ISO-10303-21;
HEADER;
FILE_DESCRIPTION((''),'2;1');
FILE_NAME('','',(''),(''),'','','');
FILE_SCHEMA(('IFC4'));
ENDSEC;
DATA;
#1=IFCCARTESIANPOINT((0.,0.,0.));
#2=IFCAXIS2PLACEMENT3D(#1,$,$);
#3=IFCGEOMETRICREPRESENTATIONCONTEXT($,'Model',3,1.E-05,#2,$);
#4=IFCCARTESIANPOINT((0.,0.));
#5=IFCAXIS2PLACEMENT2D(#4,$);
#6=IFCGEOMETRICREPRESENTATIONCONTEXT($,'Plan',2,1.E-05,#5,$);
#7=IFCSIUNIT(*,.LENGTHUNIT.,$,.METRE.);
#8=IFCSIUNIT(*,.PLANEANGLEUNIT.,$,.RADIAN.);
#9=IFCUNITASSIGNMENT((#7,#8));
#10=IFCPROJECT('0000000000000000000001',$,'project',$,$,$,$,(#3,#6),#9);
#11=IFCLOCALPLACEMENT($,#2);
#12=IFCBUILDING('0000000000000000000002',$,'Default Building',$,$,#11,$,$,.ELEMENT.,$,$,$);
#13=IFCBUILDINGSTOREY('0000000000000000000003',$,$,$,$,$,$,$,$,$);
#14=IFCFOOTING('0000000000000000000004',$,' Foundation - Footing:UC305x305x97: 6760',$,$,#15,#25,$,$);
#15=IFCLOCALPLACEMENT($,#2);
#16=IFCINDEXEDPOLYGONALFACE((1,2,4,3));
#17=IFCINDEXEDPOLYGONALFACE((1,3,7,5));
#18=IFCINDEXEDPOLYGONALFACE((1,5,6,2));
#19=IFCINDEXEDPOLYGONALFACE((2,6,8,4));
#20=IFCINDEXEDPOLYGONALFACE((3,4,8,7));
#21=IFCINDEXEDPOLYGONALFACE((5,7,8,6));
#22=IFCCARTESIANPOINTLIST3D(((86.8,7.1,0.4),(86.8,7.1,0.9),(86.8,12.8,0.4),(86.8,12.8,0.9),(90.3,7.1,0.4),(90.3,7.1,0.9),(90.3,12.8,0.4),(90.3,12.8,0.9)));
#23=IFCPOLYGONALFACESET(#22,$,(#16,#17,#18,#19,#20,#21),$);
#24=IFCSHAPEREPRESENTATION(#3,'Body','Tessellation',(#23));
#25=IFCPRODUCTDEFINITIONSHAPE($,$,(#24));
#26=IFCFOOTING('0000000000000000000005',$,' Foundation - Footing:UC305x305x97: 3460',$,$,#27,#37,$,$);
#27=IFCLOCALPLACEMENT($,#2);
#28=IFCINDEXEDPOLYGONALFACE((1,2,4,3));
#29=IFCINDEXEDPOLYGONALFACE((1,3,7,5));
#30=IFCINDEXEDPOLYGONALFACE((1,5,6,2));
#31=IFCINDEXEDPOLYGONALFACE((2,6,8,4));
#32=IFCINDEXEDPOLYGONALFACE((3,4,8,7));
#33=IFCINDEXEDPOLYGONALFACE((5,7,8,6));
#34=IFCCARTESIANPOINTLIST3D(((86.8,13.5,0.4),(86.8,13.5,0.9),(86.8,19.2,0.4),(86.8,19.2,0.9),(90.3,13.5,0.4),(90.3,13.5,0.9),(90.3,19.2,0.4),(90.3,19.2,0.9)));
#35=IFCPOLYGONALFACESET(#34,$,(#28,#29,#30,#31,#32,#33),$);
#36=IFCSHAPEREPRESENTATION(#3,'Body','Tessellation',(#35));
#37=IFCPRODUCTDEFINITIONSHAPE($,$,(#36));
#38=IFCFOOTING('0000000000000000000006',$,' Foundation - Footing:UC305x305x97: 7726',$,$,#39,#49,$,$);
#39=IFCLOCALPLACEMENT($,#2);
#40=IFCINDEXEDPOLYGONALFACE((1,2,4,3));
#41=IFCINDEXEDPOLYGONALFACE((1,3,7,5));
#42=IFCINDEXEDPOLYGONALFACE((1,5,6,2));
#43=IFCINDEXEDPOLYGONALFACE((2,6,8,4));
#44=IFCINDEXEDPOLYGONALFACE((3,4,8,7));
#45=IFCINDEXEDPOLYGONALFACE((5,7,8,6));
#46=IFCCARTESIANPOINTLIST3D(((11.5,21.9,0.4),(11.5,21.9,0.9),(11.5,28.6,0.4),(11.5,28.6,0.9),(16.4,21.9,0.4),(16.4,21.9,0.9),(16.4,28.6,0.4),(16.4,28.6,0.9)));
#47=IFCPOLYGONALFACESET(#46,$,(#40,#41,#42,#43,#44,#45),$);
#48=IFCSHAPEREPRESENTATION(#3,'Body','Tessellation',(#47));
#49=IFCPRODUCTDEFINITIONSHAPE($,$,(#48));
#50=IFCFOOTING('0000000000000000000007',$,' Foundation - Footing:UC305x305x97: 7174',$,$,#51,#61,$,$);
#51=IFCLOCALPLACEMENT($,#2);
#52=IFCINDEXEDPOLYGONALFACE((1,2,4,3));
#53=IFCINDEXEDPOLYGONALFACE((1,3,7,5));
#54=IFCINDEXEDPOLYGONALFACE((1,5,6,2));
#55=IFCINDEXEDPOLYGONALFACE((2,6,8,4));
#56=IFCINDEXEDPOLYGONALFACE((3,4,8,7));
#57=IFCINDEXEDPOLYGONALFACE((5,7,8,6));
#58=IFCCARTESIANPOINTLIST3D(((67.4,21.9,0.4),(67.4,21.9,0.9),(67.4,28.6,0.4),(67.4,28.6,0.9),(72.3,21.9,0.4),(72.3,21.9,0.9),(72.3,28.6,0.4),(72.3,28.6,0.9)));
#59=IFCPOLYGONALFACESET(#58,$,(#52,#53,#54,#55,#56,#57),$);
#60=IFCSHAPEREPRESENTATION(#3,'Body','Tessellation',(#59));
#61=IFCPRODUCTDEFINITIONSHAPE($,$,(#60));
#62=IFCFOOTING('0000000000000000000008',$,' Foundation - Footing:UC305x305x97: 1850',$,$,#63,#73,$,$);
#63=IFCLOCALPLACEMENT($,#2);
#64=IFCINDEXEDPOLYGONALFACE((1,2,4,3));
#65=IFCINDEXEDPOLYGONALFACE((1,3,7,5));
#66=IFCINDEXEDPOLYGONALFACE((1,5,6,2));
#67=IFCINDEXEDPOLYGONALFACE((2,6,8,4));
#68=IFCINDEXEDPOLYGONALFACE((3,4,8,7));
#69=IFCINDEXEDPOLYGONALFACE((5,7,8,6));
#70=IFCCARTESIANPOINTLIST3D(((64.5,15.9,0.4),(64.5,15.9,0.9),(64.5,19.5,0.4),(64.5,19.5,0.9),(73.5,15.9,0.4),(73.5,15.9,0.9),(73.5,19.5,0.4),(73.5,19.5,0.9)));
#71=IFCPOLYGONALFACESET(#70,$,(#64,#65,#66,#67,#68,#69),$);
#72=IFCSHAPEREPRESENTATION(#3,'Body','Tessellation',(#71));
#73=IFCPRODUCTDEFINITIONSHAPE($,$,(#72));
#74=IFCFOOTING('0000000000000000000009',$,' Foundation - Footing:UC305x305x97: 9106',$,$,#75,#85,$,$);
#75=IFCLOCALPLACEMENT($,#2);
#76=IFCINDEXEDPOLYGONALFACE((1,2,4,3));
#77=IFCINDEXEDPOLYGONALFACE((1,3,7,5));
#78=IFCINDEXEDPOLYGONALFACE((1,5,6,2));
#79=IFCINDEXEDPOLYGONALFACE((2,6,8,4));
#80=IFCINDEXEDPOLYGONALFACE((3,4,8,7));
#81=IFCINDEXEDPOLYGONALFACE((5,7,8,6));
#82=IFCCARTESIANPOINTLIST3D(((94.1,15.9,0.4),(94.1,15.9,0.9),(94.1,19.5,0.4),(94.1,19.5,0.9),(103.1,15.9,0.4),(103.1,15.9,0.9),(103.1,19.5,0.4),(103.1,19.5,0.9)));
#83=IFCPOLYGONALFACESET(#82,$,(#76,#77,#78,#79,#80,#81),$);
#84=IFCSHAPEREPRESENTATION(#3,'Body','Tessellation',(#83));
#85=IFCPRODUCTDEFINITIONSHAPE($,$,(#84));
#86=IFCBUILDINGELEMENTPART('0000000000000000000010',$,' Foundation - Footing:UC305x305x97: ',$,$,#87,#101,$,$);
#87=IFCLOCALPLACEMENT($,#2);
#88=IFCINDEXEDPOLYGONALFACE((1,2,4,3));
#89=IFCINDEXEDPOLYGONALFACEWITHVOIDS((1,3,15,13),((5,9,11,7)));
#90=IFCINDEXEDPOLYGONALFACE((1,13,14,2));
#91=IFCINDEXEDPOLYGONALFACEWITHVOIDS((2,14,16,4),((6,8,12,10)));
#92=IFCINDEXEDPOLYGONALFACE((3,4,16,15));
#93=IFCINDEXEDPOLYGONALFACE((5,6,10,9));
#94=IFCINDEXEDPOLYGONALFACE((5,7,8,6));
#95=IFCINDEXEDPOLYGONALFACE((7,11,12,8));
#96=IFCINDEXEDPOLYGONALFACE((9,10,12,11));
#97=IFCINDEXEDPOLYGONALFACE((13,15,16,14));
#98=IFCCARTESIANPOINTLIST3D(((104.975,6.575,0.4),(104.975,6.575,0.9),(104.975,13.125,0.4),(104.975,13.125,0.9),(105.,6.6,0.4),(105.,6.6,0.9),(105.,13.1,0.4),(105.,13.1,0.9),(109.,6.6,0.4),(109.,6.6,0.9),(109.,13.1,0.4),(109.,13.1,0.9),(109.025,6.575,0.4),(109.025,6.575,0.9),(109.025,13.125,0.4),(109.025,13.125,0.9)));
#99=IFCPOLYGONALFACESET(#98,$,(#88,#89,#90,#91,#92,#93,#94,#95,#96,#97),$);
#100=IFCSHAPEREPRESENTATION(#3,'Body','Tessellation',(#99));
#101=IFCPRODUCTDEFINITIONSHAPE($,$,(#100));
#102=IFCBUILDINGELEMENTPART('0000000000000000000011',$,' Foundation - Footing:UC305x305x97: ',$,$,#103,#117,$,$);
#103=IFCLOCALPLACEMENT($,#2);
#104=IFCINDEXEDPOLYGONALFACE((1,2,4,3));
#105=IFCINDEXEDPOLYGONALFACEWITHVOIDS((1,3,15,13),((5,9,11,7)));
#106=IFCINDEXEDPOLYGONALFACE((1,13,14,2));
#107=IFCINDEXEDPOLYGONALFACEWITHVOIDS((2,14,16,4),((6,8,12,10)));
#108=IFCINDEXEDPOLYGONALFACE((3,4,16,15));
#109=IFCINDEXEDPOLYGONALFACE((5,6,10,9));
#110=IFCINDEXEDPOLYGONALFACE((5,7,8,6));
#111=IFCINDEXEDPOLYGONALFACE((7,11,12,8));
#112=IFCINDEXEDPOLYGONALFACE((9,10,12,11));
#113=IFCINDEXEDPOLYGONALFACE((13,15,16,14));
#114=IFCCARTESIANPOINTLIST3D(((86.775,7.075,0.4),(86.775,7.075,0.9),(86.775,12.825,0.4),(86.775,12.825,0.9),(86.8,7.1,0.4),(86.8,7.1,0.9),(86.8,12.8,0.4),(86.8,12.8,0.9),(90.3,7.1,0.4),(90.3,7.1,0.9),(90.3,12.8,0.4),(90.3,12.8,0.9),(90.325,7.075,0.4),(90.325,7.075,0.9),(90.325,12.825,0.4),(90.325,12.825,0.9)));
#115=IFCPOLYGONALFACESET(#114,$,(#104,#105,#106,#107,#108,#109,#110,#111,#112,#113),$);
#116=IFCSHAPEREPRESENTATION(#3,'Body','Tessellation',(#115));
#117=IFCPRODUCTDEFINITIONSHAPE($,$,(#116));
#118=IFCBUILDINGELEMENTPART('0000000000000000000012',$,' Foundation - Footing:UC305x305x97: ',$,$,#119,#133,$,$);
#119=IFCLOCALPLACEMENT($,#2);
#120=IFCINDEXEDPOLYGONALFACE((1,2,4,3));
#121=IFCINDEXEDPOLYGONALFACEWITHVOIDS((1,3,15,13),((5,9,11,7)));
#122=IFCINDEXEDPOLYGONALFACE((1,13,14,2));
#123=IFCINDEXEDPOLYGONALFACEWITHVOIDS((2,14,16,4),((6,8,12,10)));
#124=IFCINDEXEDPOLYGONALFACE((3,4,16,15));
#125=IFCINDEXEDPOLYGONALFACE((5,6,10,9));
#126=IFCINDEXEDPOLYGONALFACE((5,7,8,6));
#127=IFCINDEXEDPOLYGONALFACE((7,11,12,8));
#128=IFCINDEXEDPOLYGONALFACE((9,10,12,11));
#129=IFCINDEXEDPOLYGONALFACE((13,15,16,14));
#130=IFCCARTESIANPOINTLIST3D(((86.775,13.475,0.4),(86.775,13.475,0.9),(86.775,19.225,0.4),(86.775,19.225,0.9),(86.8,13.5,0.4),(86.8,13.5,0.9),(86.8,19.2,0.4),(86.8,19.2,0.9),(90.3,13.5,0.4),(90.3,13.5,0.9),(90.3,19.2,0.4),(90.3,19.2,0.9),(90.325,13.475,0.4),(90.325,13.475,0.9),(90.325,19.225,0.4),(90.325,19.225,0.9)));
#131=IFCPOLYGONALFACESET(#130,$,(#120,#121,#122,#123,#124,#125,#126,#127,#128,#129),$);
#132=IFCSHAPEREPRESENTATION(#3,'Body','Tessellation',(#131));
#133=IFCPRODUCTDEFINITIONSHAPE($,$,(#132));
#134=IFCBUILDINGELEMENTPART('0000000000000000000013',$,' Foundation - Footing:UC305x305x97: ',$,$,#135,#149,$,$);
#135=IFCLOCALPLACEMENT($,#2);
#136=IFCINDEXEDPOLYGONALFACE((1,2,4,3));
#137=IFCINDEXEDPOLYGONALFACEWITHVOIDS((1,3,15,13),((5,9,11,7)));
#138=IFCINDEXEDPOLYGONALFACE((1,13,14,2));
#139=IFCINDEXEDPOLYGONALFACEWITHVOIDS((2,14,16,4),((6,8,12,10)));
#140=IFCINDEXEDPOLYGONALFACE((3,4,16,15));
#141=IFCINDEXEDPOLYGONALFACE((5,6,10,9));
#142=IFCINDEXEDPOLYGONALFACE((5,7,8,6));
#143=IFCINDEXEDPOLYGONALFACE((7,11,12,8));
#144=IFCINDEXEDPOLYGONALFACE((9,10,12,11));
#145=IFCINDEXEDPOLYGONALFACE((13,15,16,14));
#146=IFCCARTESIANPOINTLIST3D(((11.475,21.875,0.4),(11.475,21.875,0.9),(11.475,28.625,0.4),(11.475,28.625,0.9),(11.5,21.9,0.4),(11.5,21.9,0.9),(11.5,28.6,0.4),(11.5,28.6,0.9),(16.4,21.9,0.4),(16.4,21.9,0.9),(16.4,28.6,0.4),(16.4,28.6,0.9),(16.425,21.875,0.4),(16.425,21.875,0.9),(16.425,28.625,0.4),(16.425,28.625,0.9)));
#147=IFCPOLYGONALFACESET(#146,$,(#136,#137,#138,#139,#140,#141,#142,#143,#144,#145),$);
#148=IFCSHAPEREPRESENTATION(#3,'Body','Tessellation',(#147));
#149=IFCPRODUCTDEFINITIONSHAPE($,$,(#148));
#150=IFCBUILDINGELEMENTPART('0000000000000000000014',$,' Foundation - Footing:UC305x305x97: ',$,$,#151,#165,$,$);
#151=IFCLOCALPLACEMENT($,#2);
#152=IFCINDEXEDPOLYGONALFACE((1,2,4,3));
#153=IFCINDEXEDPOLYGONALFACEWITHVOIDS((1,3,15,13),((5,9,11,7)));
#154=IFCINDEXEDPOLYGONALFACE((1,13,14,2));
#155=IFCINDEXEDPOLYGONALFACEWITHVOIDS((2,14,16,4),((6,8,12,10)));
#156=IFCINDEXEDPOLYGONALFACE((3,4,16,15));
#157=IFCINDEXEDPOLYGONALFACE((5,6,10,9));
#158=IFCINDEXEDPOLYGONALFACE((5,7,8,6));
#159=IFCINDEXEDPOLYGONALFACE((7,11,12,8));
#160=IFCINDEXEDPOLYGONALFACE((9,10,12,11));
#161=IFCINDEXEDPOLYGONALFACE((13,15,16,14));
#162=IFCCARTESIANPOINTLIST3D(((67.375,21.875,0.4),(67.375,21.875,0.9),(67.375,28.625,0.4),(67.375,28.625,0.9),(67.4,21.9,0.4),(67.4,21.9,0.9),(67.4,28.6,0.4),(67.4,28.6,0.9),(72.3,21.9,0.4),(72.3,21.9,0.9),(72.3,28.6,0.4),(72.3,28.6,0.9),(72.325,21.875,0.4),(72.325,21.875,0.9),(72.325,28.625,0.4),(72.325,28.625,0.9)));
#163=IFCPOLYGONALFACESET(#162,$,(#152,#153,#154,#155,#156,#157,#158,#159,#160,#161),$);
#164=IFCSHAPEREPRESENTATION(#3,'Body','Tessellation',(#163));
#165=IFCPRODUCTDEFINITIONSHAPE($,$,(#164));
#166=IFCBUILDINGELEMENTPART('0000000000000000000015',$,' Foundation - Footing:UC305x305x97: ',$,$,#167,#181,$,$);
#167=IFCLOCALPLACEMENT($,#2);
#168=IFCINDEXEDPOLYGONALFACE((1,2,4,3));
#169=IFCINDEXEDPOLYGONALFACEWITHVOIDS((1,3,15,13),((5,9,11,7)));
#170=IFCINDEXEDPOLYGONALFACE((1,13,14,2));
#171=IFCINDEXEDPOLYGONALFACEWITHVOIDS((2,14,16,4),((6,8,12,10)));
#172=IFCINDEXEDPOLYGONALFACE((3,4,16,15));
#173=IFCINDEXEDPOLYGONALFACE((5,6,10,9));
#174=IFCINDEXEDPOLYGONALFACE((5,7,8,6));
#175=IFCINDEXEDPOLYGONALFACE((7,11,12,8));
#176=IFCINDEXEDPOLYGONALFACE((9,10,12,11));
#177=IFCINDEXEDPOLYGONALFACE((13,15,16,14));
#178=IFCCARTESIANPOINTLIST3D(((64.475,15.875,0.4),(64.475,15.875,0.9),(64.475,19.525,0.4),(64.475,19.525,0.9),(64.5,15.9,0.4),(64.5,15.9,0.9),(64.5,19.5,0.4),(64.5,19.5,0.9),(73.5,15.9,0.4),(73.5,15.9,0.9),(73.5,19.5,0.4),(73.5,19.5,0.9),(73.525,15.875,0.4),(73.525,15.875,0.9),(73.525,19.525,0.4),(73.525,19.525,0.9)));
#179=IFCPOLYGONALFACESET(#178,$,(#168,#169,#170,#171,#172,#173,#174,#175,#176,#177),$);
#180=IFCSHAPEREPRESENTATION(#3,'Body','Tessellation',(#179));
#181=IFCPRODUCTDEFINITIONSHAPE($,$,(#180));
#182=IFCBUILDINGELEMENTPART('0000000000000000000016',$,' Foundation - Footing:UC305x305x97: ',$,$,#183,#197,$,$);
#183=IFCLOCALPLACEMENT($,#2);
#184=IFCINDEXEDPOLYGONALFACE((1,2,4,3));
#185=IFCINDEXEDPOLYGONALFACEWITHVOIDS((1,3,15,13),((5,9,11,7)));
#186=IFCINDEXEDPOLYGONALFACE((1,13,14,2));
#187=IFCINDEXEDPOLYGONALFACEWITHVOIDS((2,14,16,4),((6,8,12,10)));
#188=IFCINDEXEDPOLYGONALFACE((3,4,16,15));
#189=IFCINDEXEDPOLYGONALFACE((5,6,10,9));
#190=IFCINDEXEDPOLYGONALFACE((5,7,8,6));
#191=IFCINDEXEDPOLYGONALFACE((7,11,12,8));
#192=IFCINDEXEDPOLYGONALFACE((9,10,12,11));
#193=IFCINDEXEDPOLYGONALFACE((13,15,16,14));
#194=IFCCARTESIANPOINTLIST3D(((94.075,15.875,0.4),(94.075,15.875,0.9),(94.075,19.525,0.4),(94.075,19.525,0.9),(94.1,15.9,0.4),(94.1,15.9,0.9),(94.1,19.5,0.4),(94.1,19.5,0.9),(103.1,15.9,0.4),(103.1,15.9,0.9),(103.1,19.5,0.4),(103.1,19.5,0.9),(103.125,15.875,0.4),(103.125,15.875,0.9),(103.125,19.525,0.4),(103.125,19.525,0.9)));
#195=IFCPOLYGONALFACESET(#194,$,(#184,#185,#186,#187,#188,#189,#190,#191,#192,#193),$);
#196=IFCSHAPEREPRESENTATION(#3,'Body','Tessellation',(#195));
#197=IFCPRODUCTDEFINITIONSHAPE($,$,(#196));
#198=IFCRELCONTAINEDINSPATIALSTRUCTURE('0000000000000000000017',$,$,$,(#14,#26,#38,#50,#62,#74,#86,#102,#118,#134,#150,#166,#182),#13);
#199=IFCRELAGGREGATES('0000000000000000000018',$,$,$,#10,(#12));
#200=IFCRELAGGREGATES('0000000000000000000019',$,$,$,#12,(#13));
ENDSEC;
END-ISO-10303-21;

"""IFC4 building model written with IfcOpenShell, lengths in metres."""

from ifc_helpers import new_model, si_unit, origin, origin_2d, place, context, project, spatial, polyline, outline, extrude, element, save


model = new_model("IFC4")

# Units and contexts
model_context = context("Model", 3, precision=1e-05, world=origin())
plan_context = context("Plan", 2, precision=1e-05, world=origin_2d())
ifc_project = project(units=[si_unit("LENGTHUNIT", "METRE"), si_unit("PLANEANGLEUNIT", "RADIAN")], contexts=[model_context, plan_context])

# Building, storey
building_placement = place(None, origin())
building = spatial("IfcBuilding", under=ifc_project, at=building_placement, Name="Default Building", CompositionType="ELEMENT")
storey = spatial("IfcBuildingStorey", under=building)

# Footings
element("IfcFooting", 1, inside=storey, Name=" Foundation - Footing:UC305x305x97: 6760", context=model_context, shape_type="SweptSolid", body=[
    extrude(outline(polyline([(86.8, 12.8, 0.4), (90.3, 12.8, 0.4), (90.3, 7.1, 0.4), (86.8, 7.1, 0.4), (86.8, 12.8, 0.4)])), None, (0.0, 0.0, 1.0), 0.5),
])
element("IfcFooting", 2, inside=storey, Name=" Foundation - Footing:UC305x305x97: 3460", context=model_context, shape_type="SweptSolid", body=[
    extrude(outline(polyline([(86.8, 19.2, 0.4), (90.3, 19.2, 0.4), (90.3, 13.5, 0.4), (86.8, 13.5, 0.4), (86.8, 19.2, 0.4)])), None, (0.0, 0.0, 1.0), 0.5),
])
element("IfcFooting", 3, inside=storey, Name=" Foundation - Footing:UC305x305x97: 7726", context=model_context, shape_type="SweptSolid", body=[
    extrude(outline(polyline([(16.4, 21.9, 0.4), (16.4, 28.6, 0.4), (11.5, 28.6, 0.4), (11.5, 21.9, 0.4), (16.4, 21.9, 0.4)])), None, (0.0, 0.0, 1.0), 0.5),
])
element("IfcFooting", 4, inside=storey, Name=" Foundation - Footing:UC305x305x97: 7174", context=model_context, shape_type="SweptSolid", body=[
    extrude(outline(polyline([(67.4, 21.9, 0.4), (67.4, 28.6, 0.4), (72.3, 28.6, 0.4), (72.3, 21.9, 0.4), (67.4, 21.9, 0.4)])), None, (0.0, 0.0, 1.0), 0.5),
])
element("IfcFooting", 5, inside=storey, Name=" Foundation - Footing:UC305x305x97: 1850", context=model_context, shape_type="SweptSolid", body=[
    extrude(outline(polyline([(64.5, 19.5, 0.4), (73.5, 19.5, 0.4), (73.5, 15.9, 0.4), (64.5, 15.9, 0.4), (64.5, 19.5, 0.4)])), None, (0.0, 0.0, 1.0), 0.5),
])
element("IfcFooting", 6, inside=storey, Name=" Foundation - Footing:UC305x305x97: 9106", context=model_context, shape_type="SweptSolid", body=[
    extrude(outline(polyline([(94.1, 19.5, 0.4), (103.1, 19.5, 0.4), (103.1, 15.9, 0.4), (94.1, 15.9, 0.4), (94.1, 19.5, 0.4)])), None, (0.0, 0.0, 1.0), 0.5),
])

# Building element parts, openings
building_element_part_1 = element("IfcBuildingElementPart", 7, inside=storey, Name=" Foundation - Footing:UC305x305x97: ", context=model_context, shape_type="SweptSolid", body=[
    extrude(outline(polyline([(109.025, 13.125, 0.4), (104.975, 13.125, 0.4), (104.975, 6.575, 0.4), (109.025, 6.575, 0.4), (109.025, 13.125, 0.4)])), None, (0.0, 0.0, 1.0), 0.5),
])
element("IfcOpeningElement", 8, inside=storey, cuts=building_element_part_1, context=model_context, shape_type="SweptSolid", body=[
    extrude(outline(polyline([(109.0, 13.1, 0.4), (105.0, 13.1, 0.4), (105.0, 6.6, 0.4), (109.0, 6.6, 0.4), (109.0, 13.1, 0.4)])), None, (0.0, 0.0, 1.0), 0.5),
])
building_element_part_2 = element("IfcBuildingElementPart", 9, inside=storey, Name=" Foundation - Footing:UC305x305x97: ", context=model_context, shape_type="SweptSolid", body=[
    extrude(outline(polyline([(86.775, 12.825, 0.4), (90.325, 12.825, 0.4), (90.325, 7.075, 0.4), (86.775, 7.075, 0.4), (86.775, 12.825, 0.4)])), None, (0.0, 0.0, 1.0), 0.5),
])
element("IfcOpeningElement", 10, inside=storey, cuts=building_element_part_2, context=model_context, shape_type="SweptSolid", body=[
    extrude(outline(polyline([(86.8, 12.8, 0.4), (90.3, 12.8, 0.4), (90.3, 7.1, 0.4), (86.8, 7.1, 0.4), (86.8, 12.8, 0.4)])), None, (0.0, 0.0, 1.0), 0.5),
])
building_element_part_3 = element("IfcBuildingElementPart", 11, inside=storey, Name=" Foundation - Footing:UC305x305x97: ", context=model_context, shape_type="SweptSolid", body=[
    extrude(outline(polyline([(86.775, 19.225, 0.4), (90.325, 19.225, 0.4), (90.325, 13.475, 0.4), (86.775, 13.475, 0.4), (86.775, 19.225, 0.4)])), None, (0.0, 0.0, 1.0), 0.5),
])
element("IfcOpeningElement", 12, inside=storey, cuts=building_element_part_3, context=model_context, shape_type="SweptSolid", body=[
    extrude(outline(polyline([(86.8, 19.2, 0.4), (90.3, 19.2, 0.4), (90.3, 13.5, 0.4), (86.8, 13.5, 0.4), (86.8, 19.2, 0.4)])), None, (0.0, 0.0, 1.0), 0.5),
])
building_element_part_4 = element("IfcBuildingElementPart", 13, inside=storey, Name=" Foundation - Footing:UC305x305x97: ", context=model_context, shape_type="SweptSolid", body=[
    extrude(outline(polyline([(16.425, 21.875, 0.4), (16.425, 28.625, 0.4), (11.475, 28.625, 0.4), (11.475, 21.875, 0.4), (16.425, 21.875, 0.4)])), None, (0.0, 0.0, 1.0), 0.5),
])
element("IfcOpeningElement", 14, inside=storey, cuts=building_element_part_4, context=model_context, shape_type="SweptSolid", body=[
    extrude(outline(polyline([(16.4, 21.9, 0.4), (16.4, 28.6, 0.4), (11.5, 28.6, 0.4), (11.5, 21.9, 0.4), (16.4, 21.9, 0.4)])), None, (0.0, 0.0, 1.0), 0.5),
])
building_element_part_5 = element("IfcBuildingElementPart", 15, inside=storey, Name=" Foundation - Footing:UC305x305x97: ", context=model_context, shape_type="SweptSolid", body=[
    extrude(outline(polyline([(67.375, 21.875, 0.4), (67.375, 28.625, 0.4), (72.325, 28.625, 0.4), (72.325, 21.875, 0.4), (67.375, 21.875, 0.4)])), None, (0.0, 0.0, 1.0), 0.5),
])
element("IfcOpeningElement", 16, inside=storey, cuts=building_element_part_5, context=model_context, shape_type="SweptSolid", body=[
    extrude(outline(polyline([(67.4, 21.9, 0.4), (67.4, 28.6, 0.4), (72.3, 28.6, 0.4), (72.3, 21.9, 0.4), (67.4, 21.9, 0.4)])), None, (0.0, 0.0, 1.0), 0.5),
])
building_element_part_6 = element("IfcBuildingElementPart", 17, inside=storey, Name=" Foundation - Footing:UC305x305x97: ", context=model_context, shape_type="SweptSolid", body=[
    extrude(outline(polyline([(64.475, 19.525, 0.4), (73.525, 19.525, 0.4), (73.525, 15.875, 0.4), (64.475, 15.875, 0.4), (64.475, 19.525, 0.4)])), None, (0.0, 0.0, 1.0), 0.5),
])
element("IfcOpeningElement", 18, inside=storey, cuts=building_element_part_6, context=model_context, shape_type="SweptSolid", body=[
    extrude(outline(polyline([(64.5, 19.5, 0.4), (73.5, 19.5, 0.4), (73.5, 15.9, 0.4), (64.5, 15.9, 0.4), (64.5, 19.5, 0.4)])), None, (0.0, 0.0, 1.0), 0.5),
])
building_element_part_7 = element("IfcBuildingElementPart", 19, inside=storey, Name=" Foundation - Footing:UC305x305x97: ", context=model_context, shape_type="SweptSolid", body=[
    extrude(outline(polyline([(94.075, 19.525, 0.4), (103.125, 19.525, 0.4), (103.125, 15.875, 0.4), (94.075, 15.875, 0.4), (94.075, 19.525, 0.4)])), None, (0.0, 0.0, 1.0), 0.5),
])
element("IfcOpeningElement", 20, inside=storey, cuts=building_element_part_7, context=model_context, shape_type="SweptSolid", body=[
    extrude(outline(polyline([(94.1, 19.5, 0.4), (103.1, 19.5, 0.4), (103.1, 15.9, 0.4), (94.1, 15.9, 0.4), (94.1, 19.5, 0.4)])), None, (0.0, 0.0, 1.0), 0.5),
])

save(model, "model.ifc")
